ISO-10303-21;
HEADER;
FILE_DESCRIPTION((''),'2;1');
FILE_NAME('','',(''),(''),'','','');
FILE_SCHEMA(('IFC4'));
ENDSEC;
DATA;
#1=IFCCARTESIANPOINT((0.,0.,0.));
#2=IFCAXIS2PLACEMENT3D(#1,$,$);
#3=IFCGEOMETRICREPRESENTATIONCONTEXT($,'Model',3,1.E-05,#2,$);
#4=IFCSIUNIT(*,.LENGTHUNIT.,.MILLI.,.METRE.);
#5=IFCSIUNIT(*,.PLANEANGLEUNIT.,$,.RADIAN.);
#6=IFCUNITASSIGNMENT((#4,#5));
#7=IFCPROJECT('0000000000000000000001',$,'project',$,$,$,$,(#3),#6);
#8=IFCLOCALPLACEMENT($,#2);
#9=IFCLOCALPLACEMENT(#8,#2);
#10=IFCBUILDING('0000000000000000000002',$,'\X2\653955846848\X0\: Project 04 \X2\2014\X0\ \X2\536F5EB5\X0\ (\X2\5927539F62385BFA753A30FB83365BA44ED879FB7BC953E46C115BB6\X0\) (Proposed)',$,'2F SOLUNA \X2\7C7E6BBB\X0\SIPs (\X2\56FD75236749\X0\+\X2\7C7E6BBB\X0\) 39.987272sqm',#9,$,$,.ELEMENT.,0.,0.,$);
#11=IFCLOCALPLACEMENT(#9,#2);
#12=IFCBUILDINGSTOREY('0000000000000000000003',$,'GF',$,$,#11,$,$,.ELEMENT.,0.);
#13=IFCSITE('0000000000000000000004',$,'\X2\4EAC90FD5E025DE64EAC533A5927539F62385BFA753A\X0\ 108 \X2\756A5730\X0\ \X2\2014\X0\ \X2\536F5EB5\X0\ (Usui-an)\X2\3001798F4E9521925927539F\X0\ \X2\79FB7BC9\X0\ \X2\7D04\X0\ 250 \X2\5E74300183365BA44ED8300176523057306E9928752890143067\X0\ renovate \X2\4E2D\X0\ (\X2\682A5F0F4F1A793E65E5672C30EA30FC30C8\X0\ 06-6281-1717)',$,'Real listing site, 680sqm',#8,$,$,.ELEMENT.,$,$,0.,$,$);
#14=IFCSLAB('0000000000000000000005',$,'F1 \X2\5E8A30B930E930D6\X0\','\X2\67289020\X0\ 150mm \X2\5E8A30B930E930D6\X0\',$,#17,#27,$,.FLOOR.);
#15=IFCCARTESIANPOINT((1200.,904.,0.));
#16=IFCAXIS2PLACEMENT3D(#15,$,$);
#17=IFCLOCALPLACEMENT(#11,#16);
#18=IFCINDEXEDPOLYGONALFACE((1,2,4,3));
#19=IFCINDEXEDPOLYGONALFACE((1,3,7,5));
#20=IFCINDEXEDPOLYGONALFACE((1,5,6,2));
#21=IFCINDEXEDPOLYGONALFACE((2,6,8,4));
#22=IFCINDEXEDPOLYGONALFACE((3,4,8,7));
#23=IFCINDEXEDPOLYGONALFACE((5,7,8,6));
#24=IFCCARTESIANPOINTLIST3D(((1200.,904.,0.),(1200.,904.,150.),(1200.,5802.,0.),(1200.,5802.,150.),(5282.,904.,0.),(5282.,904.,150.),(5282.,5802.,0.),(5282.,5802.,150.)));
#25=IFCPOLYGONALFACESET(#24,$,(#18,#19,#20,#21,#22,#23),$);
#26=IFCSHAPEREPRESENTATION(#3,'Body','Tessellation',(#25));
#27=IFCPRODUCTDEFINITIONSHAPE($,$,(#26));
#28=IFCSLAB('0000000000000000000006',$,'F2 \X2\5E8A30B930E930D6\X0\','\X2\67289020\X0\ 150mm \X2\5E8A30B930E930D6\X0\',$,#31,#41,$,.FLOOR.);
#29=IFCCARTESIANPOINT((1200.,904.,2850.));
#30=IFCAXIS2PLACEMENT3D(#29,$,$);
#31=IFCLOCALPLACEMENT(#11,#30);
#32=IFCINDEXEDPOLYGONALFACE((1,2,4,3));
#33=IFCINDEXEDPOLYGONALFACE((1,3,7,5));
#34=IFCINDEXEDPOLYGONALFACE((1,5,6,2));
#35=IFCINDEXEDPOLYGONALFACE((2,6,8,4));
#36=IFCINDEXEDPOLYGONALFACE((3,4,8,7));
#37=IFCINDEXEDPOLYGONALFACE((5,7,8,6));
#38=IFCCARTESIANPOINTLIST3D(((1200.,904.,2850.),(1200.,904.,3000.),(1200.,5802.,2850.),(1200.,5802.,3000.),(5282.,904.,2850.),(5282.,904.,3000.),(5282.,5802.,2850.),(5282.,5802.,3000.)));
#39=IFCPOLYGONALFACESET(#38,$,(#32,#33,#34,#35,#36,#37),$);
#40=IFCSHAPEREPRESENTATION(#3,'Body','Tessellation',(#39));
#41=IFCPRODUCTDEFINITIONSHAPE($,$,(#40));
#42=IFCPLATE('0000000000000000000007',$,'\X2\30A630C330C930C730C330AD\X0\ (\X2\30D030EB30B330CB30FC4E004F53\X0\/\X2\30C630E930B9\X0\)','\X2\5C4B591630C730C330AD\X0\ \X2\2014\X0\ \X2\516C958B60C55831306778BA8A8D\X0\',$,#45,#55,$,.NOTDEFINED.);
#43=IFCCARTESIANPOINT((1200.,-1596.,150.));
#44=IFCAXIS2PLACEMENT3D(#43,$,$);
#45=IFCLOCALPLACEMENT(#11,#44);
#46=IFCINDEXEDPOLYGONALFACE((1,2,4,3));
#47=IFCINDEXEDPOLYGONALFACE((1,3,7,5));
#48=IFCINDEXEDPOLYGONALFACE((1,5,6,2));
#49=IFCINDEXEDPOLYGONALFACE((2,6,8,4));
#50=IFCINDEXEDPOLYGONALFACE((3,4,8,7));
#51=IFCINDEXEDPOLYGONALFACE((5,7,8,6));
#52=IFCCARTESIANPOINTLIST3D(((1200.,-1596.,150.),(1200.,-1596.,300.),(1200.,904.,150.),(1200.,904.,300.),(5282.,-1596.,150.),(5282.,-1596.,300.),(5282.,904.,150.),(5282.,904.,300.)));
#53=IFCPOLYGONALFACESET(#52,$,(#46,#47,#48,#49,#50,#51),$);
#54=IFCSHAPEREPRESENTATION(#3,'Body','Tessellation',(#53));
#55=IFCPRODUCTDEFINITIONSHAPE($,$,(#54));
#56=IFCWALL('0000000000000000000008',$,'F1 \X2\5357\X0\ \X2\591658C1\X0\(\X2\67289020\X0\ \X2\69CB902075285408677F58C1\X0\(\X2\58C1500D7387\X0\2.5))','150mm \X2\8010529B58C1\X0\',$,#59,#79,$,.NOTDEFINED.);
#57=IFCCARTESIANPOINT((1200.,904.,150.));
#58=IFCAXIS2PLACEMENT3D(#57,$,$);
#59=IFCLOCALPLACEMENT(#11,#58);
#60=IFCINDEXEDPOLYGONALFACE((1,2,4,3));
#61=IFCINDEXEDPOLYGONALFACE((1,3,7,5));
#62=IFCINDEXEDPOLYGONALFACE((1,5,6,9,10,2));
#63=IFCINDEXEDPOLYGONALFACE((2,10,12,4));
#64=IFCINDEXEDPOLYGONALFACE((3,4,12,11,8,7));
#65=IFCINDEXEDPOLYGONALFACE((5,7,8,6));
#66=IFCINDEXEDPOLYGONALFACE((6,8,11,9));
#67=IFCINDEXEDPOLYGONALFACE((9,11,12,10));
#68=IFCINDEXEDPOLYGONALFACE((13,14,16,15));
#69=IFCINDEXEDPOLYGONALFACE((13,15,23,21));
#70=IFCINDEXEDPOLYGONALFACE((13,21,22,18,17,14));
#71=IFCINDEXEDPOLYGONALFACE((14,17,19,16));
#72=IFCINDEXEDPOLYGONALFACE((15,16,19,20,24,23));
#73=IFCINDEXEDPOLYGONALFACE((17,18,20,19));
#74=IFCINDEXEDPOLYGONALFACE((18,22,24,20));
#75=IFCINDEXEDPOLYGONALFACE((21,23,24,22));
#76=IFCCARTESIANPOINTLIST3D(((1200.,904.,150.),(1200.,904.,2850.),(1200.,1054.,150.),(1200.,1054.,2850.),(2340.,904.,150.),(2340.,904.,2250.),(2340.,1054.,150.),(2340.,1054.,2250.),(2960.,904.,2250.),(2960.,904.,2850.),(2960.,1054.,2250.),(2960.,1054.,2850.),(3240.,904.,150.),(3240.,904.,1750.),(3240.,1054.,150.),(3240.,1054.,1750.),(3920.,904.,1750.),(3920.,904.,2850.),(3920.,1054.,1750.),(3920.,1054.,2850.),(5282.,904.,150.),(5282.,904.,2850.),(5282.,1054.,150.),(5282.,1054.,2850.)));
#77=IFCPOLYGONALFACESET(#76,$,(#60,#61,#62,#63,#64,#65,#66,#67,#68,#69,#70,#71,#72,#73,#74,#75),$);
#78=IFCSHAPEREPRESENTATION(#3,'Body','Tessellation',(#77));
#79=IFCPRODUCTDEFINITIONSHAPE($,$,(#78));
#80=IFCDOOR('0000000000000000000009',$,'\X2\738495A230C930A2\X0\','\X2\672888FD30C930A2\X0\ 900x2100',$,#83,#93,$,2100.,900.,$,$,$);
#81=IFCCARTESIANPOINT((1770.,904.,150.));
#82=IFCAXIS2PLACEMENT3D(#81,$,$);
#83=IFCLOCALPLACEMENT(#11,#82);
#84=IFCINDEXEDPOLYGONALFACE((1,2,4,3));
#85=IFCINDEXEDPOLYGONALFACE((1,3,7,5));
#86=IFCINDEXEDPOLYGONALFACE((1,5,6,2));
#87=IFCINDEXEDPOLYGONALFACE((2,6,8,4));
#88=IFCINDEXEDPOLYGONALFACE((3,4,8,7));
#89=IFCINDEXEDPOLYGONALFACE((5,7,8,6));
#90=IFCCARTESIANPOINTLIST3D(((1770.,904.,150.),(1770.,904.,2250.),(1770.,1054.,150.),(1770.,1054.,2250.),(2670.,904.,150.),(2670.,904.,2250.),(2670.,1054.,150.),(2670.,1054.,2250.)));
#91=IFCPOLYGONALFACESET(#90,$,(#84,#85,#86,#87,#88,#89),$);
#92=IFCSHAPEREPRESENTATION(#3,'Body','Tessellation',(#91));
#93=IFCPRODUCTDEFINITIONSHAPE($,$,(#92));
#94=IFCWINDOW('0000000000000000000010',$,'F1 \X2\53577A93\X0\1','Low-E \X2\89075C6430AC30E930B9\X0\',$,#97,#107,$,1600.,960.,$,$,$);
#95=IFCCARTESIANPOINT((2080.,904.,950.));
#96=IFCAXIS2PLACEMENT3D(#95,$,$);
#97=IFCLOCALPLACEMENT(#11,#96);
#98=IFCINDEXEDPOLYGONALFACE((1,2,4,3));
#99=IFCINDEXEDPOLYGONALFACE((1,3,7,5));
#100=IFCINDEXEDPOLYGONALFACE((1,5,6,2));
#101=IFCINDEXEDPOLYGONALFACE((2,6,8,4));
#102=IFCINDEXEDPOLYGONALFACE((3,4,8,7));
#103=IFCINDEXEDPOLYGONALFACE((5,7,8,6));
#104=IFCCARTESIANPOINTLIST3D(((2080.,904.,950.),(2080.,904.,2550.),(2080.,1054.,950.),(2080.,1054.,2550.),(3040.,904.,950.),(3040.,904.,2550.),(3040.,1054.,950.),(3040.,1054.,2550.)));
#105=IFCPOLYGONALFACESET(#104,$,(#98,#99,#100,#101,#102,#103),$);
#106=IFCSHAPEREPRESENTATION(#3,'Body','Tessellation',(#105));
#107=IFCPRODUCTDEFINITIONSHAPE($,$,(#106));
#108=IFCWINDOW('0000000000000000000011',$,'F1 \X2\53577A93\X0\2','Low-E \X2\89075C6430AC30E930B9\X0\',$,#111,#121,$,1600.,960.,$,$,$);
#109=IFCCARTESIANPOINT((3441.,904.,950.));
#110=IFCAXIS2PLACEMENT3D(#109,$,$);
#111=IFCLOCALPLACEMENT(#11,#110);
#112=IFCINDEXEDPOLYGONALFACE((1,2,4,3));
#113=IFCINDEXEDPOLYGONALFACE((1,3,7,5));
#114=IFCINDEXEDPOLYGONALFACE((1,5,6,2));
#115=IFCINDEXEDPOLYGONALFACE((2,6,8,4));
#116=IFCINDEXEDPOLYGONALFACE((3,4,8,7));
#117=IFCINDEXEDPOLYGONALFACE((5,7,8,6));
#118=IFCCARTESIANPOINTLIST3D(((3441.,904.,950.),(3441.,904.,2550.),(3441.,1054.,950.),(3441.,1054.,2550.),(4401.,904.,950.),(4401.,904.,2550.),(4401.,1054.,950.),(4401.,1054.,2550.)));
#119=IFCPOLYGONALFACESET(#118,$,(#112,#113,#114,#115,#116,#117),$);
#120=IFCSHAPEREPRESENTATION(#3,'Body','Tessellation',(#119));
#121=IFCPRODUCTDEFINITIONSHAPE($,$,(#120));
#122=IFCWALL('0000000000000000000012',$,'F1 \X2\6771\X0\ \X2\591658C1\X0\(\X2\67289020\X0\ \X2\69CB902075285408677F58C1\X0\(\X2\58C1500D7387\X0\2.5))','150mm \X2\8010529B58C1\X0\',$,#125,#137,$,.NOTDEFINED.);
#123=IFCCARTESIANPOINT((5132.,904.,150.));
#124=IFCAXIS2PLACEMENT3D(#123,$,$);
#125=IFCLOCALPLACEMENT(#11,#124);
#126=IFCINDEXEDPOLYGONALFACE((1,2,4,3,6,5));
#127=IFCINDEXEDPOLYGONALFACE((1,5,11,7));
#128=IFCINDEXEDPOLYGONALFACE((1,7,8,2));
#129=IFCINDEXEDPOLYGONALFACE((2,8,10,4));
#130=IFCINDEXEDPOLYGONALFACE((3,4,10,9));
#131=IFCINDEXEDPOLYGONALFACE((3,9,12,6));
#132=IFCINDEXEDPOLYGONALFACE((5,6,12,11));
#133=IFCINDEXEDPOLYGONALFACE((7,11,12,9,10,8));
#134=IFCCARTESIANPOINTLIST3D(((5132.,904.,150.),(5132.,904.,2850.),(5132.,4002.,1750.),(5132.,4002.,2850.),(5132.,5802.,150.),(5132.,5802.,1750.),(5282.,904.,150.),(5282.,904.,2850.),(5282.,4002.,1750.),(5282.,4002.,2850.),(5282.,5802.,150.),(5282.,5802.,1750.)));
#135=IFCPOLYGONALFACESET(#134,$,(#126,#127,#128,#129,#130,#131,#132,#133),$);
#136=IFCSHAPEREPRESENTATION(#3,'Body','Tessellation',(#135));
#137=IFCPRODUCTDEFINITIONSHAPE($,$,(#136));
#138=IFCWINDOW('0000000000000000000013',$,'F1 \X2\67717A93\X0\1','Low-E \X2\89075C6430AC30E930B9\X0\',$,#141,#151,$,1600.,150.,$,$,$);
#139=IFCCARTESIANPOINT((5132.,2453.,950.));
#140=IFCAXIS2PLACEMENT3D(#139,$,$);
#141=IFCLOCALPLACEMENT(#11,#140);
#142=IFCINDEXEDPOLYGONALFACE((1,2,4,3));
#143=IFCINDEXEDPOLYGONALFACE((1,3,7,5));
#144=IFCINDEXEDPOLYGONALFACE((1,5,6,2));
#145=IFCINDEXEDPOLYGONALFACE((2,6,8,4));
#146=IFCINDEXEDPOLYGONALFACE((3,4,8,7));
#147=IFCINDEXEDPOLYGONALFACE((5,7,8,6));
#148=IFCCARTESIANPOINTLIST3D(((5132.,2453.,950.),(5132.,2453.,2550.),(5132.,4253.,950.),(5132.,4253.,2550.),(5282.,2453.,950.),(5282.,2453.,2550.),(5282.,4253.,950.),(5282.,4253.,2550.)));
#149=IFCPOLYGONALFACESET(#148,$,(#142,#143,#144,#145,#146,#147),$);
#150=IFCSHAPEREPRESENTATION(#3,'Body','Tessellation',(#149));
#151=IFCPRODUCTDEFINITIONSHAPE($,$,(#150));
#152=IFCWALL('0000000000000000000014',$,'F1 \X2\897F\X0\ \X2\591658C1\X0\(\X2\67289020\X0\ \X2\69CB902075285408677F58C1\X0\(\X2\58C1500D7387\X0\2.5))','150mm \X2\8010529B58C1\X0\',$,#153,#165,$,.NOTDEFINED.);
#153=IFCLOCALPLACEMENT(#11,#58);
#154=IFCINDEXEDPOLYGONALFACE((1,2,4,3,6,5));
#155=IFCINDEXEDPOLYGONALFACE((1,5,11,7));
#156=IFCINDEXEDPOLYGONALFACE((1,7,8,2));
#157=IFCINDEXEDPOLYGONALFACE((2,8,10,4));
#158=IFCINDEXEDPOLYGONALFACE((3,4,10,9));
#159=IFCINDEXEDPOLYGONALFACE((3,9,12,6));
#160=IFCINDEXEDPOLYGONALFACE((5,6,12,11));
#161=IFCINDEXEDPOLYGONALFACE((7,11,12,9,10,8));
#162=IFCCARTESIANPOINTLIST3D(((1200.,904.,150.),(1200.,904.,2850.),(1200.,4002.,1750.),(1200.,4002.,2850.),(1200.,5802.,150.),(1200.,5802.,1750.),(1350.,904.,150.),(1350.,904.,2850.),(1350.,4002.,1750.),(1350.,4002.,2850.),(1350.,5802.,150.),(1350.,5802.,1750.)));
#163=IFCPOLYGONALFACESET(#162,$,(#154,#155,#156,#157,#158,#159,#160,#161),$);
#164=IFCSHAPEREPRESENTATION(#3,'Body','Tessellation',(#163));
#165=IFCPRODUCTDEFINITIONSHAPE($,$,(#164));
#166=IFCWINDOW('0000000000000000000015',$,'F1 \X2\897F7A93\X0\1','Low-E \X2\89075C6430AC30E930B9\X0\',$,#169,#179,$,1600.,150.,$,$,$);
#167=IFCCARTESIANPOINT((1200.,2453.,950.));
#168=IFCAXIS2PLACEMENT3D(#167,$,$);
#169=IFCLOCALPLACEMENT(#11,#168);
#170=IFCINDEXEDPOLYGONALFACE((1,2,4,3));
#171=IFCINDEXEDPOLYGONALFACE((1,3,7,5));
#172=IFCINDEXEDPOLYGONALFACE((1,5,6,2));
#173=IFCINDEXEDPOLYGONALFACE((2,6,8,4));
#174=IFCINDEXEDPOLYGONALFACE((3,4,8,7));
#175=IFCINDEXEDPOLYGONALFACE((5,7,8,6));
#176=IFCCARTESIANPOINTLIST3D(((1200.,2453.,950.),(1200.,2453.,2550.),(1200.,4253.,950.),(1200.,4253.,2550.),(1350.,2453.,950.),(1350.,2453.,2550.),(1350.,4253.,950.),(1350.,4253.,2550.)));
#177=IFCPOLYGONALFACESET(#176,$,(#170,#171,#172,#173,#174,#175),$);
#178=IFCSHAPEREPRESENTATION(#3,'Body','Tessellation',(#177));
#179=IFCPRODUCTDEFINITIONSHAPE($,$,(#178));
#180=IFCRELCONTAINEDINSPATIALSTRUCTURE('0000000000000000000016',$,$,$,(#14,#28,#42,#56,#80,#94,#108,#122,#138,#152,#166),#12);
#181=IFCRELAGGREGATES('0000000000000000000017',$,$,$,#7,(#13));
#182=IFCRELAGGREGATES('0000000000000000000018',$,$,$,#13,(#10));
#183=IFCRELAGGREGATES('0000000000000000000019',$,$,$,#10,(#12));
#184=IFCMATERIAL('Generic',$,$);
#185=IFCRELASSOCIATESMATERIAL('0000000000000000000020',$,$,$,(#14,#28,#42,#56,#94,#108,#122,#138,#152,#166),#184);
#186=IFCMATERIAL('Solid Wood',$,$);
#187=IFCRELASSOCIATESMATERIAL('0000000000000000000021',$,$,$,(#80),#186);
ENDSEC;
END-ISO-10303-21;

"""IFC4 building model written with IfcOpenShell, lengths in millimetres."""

from ifc_helpers import new_model, si_unit, frame, frame_2d, origin, place, context, project, spatial, rectangle, extrude, material, element, fill, save


model = new_model("IFC4")

# Units and contexts
model_context = context("Model", 3, precision=1e-05, world=origin())
ifc_project = project(units=[si_unit("LENGTHUNIT", "METRE", prefix="MILLI"), si_unit("PLANEANGLEUNIT", "RADIAN")], contexts=[model_context])

# Site, building, storey
site_placement = place(None, origin())
site = spatial("IfcSite", under=ifc_project, at=site_placement, Name="京都市左京区大原戸寺町 108 番地 — 卯庵 (Usui-an)、福井→大原 移築 約 250 年、茶室付、癒しの館用途で renovate 中 (株式会社日本リート 06-6281-1717)", ObjectType="Real listing site, 680sqm", CompositionType="ELEMENT", RefElevation=0.0)
building_placement = place(site_placement, origin())
building = spatial("IfcBuilding", under=site, at=building_placement, Name="改善案: Project 04 — 卯庵 (大原戸寺町・茶室付移築古民家) (Proposed)", ObjectType="2F SOLUNA 籾殻SIPs (国産杉+籾殻) 39.987272sqm", CompositionType="ELEMENT", ElevationOfRefHeight=0.0, ElevationOfTerrain=0.0)
storey_placement = place(building_placement, origin())
storey = spatial("IfcBuildingStorey", under=building, at=storey_placement, Name="GF", CompositionType="ELEMENT", Elevation=0.0)

# Slabs
ifc_material_1 = material(Name="Generic")
slab_1_placement = place(storey_placement, frame((1200.0, 904.0, 0.0)))
element("IfcSlab", 1, at=slab_1_placement, inside=storey, material=ifc_material_1, Name="F1 床スラブ", Description="木造 150mm 床スラブ", PredefinedType="FLOOR", context=model_context, shape_type="SweptSolid", body=[
    extrude(rectangle(XDim=4082.0, YDim=4898.0, at=frame_2d((2041.0, 2449.0))), frame((1200.0, 904.0, 0.0)), (0.0, 0.0, 1.0), 150.0),
])
slab_2_placement = place(storey_placement, frame((1200.0, 904.0, 2850.0)))
element("IfcSlab", 2, at=slab_2_placement, inside=storey, material=ifc_material_1, Name="F2 床スラブ", Description="木造 150mm 床スラブ", PredefinedType="FLOOR", context=model_context, shape_type="SweptSolid", body=[
    extrude(rectangle(XDim=4082.0, YDim=4898.0, at=frame_2d((2041.0, 2449.0))), frame((1200.0, 904.0, 2850.0)), (0.0, 0.0, 1.0), 150.0),
])

# Plate
plate_placement = place(storey_placement, frame((1200.0, -1596.0, 150.0)))
element("IfcPlate", 3, at=plate_placement, inside=storey, material=ifc_material_1, Name="ウッドデッキ (バルコニー一体/テラス)", Description="屋外デッキ — 公開情報で確認", PredefinedType="NOTDEFINED", context=model_context, shape_type="SweptSolid", body=[
    extrude(rectangle(XDim=4082.0, YDim=2500.0, at=frame_2d((2041.0, 1250.0))), frame((1200.0, -1596.0, 150.0)), (0.0, 0.0, 1.0), 150.0),
])

# Wall, openings, door, windows
wall_1_placement = place(storey_placement, frame((1200.0, 904.0, 150.0)))
wall_1 = element("IfcWall", 4, at=wall_1_placement, inside=storey, material=ifc_material_1, Name="F1 南 外壁(木造 構造用合板壁(壁倍率2.5))", Description="150mm 耐力壁", PredefinedType="NOTDEFINED", context=model_context, shape_type="SweptSolid", body=[
    extrude(rectangle(XDim=4082.0, YDim=150.0, at=frame_2d((2041.0, 75.0))), frame((1200.0, 904.0, 150.0)), (0.0, 0.0, 1.0), 2700.0),
])
opening_1_placement = place(storey_placement, frame((1770.0, 904.0, 150.0)))
opening_1 = element("IfcOpeningElement", 5, at=opening_1_placement, cuts=wall_1, PredefinedType="NOTDEFINED", context=model_context, shape_type="SweptSolid", body=[
    extrude(rectangle(XDim=900.0, YDim=150.0, at=frame_2d((450.0, 75.0))), frame((1770.0, 904.0, 150.0)), (0.0, 0.0, 1.0), 2100.0),
])
opening_2_placement = place(storey_placement, frame((2080.0, 904.0, 950.0)))
opening_2 = element("IfcOpeningElement", 6, at=opening_2_placement, cuts=wall_1, PredefinedType="NOTDEFINED", context=model_context, shape_type="SweptSolid", body=[
    extrude(rectangle(XDim=960.0, YDim=150.0, at=frame_2d((480.0, 75.0))), frame((2080.0, 904.0, 950.0)), (0.0, 0.0, 1.0), 1600.0),
])
opening_3_placement = place(storey_placement, frame((3441.0, 904.0, 950.0)))
opening_3 = element("IfcOpeningElement", 7, at=opening_3_placement, cuts=wall_1, PredefinedType="NOTDEFINED", context=model_context, shape_type="SweptSolid", body=[
    extrude(rectangle(XDim=960.0, YDim=150.0, at=frame_2d((480.0, 75.0))), frame((3441.0, 904.0, 950.0)), (0.0, 0.0, 1.0), 1600.0),
])
ifc_material_2 = material(Name="Solid Wood")
door_placement = place(storey_placement, frame((1770.0, 904.0, 150.0)))
door = element("IfcDoor", 8, at=door_placement, inside=storey, material=ifc_material_2, Name="玄関ドア", Description="木製ドア 900x2100", OverallHeight=2100.0, OverallWidth=900.0, context=model_context, shape_type="SweptSolid", body=[
    extrude(rectangle(XDim=900.0, YDim=150.0, at=frame_2d((450.0, 75.0))), frame((1770.0, 904.0, 150.0)), (0.0, 0.0, 1.0), 2100.0),
])
fill(opening_1, door)
window_1_placement = place(storey_placement, frame((2080.0, 904.0, 950.0)))
window_1 = element("IfcWindow", 9, at=window_1_placement, inside=storey, material=ifc_material_1, Name="F1 南窓1", Description="Low-E 複層ガラス", OverallHeight=1600.0, OverallWidth=960.0, context=model_context, shape_type="SweptSolid", body=[
    extrude(rectangle(XDim=960.0, YDim=150.0, at=frame_2d((480.0, 75.0))), frame((2080.0, 904.0, 950.0)), (0.0, 0.0, 1.0), 1600.0),
])
fill(opening_2, window_1)
window_2_placement = place(storey_placement, frame((3441.0, 904.0, 950.0)))
window_2 = element("IfcWindow", 10, at=window_2_placement, inside=storey, material=ifc_material_1, Name="F1 南窓2", Description="Low-E 複層ガラス", OverallHeight=1600.0, OverallWidth=960.0, context=model_context, shape_type="SweptSolid", body=[
    extrude(rectangle(XDim=960.0, YDim=150.0, at=frame_2d((480.0, 75.0))), frame((3441.0, 904.0, 950.0)), (0.0, 0.0, 1.0), 1600.0),
])
fill(opening_3, window_2)

# Walls, openings, windows
wall_2_placement = place(storey_placement, frame((5132.0, 904.0, 150.0)))
wall_2 = element("IfcWall", 11, at=wall_2_placement, inside=storey, material=ifc_material_1, Name="F1 東 外壁(木造 構造用合板壁(壁倍率2.5))", Description="150mm 耐力壁", PredefinedType="NOTDEFINED", context=model_context, shape_type="SweptSolid", body=[
    extrude(rectangle(XDim=150.0, YDim=4898.0, at=frame_2d((75.0, 2449.0))), frame((5132.0, 904.0, 150.0)), (0.0, 0.0, 1.0), 2700.0),
])
opening_4_placement = place(storey_placement, frame((5132.0, 2453.0, 950.0)))
opening_4 = element("IfcOpeningElement", 12, at=opening_4_placement, cuts=wall_2, PredefinedType="NOTDEFINED", context=model_context, shape_type="SweptSolid", body=[
    extrude(rectangle(XDim=150.0, YDim=1800.0, at=frame_2d((75.0, 900.0))), frame((5132.0, 2453.0, 950.0)), (0.0, 0.0, 1.0), 1600.0),
])
window_3_placement = place(storey_placement, frame((5132.0, 2453.0, 950.0)))
window_3 = element("IfcWindow", 13, at=window_3_placement, inside=storey, material=ifc_material_1, Name="F1 東窓1", Description="Low-E 複層ガラス", OverallHeight=1600.0, OverallWidth=150.0, context=model_context, shape_type="SweptSolid", body=[
    extrude(rectangle(XDim=150.0, YDim=1800.0, at=frame_2d((75.0, 900.0))), frame((5132.0, 2453.0, 950.0)), (0.0, 0.0, 1.0), 1600.0),
])
fill(opening_4, window_3)
wall_3_placement = place(storey_placement, frame((1200.0, 904.0, 150.0)))
wall_3 = element("IfcWall", 14, at=wall_3_placement, inside=storey, material=ifc_material_1, Name="F1 西 外壁(木造 構造用合板壁(壁倍率2.5))", Description="150mm 耐力壁", PredefinedType="NOTDEFINED", context=model_context, shape_type="SweptSolid", body=[
    extrude(rectangle(XDim=150.0, YDim=4898.0, at=frame_2d((75.0, 2449.0))), frame((1200.0, 904.0, 150.0)), (0.0, 0.0, 1.0), 2700.0),
])
opening_5_placement = place(storey_placement, frame((1200.0, 2453.0, 950.0)))
opening_5 = element("IfcOpeningElement", 15, at=opening_5_placement, cuts=wall_3, PredefinedType="NOTDEFINED", context=model_context, shape_type="SweptSolid", body=[
    extrude(rectangle(XDim=150.0, YDim=1800.0, at=frame_2d((75.0, 900.0))), frame((1200.0, 2453.0, 950.0)), (0.0, 0.0, 1.0), 1600.0),
])
window_4_placement = place(storey_placement, frame((1200.0, 2453.0, 950.0)))
window_4 = element("IfcWindow", 16, at=window_4_placement, inside=storey, material=ifc_material_1, Name="F1 西窓1", Description="Low-E 複層ガラス", OverallHeight=1600.0, OverallWidth=150.0, context=model_context, shape_type="SweptSolid", body=[
    extrude(rectangle(XDim=150.0, YDim=1800.0, at=frame_2d((75.0, 900.0))), frame((1200.0, 2453.0, 950.0)), (0.0, 0.0, 1.0), 1600.0),
])
fill(opening_5, window_4)

save(model, "model.ifc")
